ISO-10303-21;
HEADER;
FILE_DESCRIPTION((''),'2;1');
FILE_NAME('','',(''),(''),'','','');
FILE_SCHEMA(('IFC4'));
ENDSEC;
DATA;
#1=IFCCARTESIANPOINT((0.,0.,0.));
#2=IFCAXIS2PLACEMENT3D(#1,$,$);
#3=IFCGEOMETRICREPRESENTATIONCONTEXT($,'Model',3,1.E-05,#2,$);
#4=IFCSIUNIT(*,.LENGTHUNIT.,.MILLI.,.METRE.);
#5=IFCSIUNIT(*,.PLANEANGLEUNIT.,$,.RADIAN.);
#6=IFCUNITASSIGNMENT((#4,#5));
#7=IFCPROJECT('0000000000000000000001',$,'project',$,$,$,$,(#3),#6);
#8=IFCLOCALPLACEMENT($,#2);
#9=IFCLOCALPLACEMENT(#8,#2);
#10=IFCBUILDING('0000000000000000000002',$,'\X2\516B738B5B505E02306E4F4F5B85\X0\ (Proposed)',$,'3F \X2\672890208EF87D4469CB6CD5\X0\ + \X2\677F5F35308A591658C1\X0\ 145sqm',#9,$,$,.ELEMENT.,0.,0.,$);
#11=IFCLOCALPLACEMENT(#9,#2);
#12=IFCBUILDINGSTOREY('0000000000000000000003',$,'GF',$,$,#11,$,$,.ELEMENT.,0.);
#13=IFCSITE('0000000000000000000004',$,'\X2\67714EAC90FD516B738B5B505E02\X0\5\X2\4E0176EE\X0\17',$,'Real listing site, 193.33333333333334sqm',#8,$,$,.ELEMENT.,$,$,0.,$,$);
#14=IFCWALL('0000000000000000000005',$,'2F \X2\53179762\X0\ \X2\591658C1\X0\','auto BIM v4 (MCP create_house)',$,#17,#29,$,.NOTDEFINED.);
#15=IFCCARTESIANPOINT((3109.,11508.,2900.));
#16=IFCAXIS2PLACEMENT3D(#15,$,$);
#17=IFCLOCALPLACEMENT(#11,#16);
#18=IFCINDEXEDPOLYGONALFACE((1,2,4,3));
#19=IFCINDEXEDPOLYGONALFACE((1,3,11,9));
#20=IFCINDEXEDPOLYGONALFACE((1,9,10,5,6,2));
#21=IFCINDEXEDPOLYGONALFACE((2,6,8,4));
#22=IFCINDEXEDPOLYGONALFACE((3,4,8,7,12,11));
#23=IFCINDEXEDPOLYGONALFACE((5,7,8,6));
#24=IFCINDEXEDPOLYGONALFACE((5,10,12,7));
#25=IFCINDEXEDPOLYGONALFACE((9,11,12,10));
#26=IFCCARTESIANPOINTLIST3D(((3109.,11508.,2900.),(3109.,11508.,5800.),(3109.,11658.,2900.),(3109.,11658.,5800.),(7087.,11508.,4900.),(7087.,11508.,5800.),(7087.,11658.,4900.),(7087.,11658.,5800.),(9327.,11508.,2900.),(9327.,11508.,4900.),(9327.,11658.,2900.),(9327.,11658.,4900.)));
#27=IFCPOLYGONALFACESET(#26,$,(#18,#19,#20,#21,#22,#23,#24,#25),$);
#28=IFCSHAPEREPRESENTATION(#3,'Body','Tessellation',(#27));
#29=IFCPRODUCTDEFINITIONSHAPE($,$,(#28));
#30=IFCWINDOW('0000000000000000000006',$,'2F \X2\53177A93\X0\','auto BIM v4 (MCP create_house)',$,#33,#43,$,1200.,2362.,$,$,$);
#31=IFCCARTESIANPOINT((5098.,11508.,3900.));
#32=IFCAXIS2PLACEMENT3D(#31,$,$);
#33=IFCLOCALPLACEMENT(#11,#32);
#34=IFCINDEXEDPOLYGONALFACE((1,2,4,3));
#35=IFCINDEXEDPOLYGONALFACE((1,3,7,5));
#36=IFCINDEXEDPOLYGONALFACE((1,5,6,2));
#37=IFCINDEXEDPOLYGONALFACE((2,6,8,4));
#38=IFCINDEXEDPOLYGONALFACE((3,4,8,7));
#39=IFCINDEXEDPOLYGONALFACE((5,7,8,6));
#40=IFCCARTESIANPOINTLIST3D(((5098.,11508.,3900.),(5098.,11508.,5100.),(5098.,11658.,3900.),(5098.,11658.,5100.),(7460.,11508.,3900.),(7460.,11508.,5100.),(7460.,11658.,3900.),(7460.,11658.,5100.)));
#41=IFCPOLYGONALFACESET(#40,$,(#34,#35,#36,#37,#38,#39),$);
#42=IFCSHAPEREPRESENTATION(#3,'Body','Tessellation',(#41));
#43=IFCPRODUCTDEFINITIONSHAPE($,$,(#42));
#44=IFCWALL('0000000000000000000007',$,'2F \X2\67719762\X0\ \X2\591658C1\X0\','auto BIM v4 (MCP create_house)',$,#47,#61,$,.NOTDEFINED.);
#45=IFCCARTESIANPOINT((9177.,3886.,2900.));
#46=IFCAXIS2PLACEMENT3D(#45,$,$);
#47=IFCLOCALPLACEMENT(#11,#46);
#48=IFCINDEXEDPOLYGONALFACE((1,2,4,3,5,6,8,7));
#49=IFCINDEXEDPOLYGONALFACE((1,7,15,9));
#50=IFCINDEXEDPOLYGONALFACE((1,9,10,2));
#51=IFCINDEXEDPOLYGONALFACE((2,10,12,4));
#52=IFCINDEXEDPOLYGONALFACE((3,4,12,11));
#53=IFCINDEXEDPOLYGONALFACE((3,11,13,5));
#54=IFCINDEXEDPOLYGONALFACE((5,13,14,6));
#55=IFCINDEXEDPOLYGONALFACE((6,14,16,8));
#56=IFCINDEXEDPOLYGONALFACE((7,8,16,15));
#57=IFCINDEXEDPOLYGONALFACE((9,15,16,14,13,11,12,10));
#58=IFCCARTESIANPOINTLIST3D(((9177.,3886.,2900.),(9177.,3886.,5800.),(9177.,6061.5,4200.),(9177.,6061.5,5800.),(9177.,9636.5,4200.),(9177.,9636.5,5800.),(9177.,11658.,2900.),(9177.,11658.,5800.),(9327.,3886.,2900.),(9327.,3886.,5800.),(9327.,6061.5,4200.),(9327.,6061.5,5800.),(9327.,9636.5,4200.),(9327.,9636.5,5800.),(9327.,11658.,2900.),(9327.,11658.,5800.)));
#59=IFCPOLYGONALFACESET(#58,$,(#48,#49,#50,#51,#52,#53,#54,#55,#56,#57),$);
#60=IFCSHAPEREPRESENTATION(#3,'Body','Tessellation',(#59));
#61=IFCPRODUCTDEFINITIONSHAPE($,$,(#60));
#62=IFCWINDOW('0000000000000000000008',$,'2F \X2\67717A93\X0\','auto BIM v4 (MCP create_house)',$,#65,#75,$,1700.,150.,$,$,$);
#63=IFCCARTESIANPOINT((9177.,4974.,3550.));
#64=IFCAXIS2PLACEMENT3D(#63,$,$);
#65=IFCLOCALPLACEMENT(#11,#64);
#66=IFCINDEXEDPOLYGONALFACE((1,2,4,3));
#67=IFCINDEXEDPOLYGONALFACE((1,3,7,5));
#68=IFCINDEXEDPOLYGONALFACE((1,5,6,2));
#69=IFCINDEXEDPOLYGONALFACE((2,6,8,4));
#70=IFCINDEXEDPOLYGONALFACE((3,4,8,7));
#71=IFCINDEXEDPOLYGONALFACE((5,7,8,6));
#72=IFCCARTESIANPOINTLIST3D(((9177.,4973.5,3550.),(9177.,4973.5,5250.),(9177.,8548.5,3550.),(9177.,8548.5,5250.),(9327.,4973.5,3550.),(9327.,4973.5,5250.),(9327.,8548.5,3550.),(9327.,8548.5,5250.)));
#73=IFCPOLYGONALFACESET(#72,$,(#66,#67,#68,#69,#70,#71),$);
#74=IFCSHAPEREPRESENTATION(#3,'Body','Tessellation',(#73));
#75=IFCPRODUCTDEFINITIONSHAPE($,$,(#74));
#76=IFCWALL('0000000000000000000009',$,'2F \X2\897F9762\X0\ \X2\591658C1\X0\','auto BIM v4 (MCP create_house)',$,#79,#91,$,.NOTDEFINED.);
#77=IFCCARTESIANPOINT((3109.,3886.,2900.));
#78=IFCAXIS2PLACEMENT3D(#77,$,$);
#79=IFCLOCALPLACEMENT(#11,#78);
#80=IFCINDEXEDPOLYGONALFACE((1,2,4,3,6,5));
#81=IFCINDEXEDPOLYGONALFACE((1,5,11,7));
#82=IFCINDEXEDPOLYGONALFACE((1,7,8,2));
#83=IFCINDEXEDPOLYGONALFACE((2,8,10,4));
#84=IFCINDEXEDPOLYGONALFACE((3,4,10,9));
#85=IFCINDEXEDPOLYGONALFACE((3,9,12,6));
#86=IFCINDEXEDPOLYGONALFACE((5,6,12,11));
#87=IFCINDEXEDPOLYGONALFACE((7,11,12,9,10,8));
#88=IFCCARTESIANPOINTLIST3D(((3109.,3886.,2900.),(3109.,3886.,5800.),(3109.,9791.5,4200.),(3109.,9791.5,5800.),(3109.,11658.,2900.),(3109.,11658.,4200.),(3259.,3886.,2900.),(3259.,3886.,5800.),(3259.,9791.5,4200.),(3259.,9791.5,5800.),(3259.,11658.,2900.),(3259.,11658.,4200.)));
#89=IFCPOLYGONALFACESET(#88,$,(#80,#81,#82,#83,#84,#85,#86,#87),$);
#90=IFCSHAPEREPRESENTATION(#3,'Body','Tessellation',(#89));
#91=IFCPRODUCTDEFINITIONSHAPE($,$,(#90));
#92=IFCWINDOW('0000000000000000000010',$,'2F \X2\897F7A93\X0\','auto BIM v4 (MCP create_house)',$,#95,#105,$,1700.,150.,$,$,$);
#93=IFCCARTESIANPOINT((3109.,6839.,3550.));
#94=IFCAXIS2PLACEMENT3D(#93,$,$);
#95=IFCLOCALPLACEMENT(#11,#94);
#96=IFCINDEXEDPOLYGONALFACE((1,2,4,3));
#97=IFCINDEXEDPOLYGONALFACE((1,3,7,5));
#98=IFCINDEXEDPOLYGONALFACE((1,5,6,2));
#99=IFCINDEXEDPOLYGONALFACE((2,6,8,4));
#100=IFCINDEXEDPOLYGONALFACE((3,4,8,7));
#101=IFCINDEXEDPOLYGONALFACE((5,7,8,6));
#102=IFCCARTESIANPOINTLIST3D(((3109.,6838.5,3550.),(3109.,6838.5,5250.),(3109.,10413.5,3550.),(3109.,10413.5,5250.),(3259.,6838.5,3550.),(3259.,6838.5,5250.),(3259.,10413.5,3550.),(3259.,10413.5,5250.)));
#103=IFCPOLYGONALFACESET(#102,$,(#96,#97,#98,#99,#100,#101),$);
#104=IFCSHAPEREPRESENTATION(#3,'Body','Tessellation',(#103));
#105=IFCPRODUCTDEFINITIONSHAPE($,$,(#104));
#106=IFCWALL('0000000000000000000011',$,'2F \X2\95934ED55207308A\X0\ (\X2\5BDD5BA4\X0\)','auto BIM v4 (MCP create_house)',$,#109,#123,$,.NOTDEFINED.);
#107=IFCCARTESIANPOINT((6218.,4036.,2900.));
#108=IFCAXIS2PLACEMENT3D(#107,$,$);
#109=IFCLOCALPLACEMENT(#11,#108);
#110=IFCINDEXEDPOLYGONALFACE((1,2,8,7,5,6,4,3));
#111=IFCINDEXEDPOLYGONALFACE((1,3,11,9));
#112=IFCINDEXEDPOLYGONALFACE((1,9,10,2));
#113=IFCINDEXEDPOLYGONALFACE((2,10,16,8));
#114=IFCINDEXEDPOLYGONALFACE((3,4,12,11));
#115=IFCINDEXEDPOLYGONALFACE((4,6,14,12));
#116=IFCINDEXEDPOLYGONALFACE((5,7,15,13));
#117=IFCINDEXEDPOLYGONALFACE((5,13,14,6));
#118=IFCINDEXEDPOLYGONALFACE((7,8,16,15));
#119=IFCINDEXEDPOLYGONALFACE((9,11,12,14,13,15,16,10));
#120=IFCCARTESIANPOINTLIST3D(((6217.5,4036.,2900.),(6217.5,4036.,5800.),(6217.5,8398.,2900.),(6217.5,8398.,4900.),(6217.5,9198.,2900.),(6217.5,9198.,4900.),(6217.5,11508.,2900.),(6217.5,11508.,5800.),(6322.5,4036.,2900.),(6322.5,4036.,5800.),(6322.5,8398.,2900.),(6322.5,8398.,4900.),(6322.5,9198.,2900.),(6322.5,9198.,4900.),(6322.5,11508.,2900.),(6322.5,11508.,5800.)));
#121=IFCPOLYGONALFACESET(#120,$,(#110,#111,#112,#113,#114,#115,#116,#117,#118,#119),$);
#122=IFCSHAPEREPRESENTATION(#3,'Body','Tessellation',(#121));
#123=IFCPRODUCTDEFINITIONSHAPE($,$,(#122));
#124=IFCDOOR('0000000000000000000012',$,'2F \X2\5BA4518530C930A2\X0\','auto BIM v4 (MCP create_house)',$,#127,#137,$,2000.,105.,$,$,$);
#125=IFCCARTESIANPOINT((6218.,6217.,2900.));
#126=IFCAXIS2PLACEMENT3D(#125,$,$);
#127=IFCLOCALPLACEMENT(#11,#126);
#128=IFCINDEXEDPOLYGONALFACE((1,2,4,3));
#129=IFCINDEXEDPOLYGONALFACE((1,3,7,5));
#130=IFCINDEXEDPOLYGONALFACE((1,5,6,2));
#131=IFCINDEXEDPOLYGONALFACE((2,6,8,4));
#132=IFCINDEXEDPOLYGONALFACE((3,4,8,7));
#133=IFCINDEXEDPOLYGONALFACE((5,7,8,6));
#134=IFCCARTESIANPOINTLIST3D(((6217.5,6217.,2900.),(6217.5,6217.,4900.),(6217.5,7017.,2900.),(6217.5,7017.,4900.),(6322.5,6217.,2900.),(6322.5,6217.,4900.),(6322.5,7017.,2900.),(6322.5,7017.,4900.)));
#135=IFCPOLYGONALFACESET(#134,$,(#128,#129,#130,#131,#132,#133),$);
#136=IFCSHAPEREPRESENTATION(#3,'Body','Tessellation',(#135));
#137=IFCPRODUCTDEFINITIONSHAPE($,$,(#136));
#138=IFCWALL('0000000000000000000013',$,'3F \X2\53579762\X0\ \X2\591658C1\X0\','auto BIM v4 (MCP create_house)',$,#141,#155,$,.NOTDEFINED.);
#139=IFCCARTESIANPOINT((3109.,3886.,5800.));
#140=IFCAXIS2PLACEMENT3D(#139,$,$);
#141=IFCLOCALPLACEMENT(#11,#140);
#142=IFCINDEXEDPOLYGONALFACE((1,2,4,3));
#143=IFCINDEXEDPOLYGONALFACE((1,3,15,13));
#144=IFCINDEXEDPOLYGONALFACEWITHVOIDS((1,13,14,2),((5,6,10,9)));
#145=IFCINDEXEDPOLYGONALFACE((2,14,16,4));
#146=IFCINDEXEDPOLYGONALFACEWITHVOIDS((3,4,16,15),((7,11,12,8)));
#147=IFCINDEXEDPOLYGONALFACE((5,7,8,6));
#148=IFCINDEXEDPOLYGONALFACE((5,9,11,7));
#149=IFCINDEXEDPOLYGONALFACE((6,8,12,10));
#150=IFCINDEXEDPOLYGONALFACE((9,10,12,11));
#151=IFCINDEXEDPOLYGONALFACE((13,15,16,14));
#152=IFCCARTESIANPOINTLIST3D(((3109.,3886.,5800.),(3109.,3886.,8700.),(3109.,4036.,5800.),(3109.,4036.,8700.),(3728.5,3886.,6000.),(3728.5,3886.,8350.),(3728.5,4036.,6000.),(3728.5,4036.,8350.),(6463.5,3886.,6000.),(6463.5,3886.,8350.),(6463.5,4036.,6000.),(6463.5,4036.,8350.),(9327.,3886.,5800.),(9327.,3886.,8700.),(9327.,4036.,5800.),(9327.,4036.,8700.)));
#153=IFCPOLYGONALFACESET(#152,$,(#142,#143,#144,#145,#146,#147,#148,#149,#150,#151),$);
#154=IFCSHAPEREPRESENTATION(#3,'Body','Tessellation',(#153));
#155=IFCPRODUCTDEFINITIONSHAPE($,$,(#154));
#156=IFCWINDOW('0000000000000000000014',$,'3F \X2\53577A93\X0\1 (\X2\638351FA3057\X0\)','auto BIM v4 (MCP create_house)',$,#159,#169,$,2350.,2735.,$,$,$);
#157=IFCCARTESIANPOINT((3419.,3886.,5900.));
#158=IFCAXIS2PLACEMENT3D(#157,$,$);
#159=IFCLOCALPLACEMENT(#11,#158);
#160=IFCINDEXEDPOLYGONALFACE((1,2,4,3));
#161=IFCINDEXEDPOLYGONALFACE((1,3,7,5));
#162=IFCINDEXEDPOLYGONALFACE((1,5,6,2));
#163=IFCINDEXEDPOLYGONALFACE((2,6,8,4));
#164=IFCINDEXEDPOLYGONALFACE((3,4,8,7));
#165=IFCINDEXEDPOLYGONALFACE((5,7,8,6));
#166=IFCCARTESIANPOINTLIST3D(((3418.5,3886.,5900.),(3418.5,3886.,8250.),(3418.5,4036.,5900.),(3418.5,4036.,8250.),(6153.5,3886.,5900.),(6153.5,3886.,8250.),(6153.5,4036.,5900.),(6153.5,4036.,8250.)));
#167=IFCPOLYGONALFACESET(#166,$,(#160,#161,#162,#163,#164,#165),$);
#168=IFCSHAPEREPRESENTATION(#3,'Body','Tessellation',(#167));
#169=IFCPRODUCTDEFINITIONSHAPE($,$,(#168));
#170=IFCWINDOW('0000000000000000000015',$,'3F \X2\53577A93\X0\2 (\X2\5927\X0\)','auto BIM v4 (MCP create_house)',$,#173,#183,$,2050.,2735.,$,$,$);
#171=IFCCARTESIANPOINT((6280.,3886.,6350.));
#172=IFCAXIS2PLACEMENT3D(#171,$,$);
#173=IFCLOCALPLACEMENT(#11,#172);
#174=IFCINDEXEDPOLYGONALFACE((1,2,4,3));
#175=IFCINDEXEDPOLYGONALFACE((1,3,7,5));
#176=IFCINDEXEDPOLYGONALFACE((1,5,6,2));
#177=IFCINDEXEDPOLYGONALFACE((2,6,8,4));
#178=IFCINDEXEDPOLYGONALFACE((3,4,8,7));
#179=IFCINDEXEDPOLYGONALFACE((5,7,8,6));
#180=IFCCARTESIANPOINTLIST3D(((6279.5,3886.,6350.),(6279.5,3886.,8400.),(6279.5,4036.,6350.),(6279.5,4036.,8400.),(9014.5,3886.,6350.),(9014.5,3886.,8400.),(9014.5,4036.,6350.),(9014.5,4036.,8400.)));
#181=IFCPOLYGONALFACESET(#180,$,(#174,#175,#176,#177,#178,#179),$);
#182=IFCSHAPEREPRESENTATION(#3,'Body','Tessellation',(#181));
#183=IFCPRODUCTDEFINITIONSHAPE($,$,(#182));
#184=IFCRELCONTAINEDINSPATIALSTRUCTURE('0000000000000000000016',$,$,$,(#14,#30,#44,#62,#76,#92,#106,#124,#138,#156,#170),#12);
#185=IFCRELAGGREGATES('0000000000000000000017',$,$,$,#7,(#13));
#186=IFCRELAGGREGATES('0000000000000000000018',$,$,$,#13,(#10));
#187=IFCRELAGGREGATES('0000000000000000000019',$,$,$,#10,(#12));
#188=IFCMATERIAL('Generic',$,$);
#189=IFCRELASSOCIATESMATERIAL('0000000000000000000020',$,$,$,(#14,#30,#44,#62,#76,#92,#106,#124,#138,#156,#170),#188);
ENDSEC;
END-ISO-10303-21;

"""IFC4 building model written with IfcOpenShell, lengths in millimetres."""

from ifc_helpers import new_model, si_unit, frame, frame_2d, origin, place, context, project, spatial, rectangle, extrude, material, element, fill, save


model = new_model("IFC4")

# Units and contexts
model_context = context("Model", 3, precision=1e-05, world=origin())
ifc_project = project(units=[si_unit("LENGTHUNIT", "METRE", prefix="MILLI"), si_unit("PLANEANGLEUNIT", "RADIAN")], contexts=[model_context])

# Site, building, storey
site_placement = place(None, origin())
site = spatial("IfcSite", under=ifc_project, at=site_placement, Name="東京都八王子市5丁目17", ObjectType="Real listing site, 193.33333333333334sqm", CompositionType="ELEMENT", RefElevation=0.0)
building_placement = place(site_placement, origin())
building = spatial("IfcBuilding", under=site, at=building_placement, Name="八王子市の住宅 (Proposed)", ObjectType="3F 木造軸組構法 + 板張り外壁 145sqm", CompositionType="ELEMENT", ElevationOfRefHeight=0.0, ElevationOfTerrain=0.0)
storey_placement = place(building_placement, origin())
storey = spatial("IfcBuildingStorey", under=building, at=storey_placement, Name="GF", CompositionType="ELEMENT", Elevation=0.0)

# Shared definitions
ifc_material = material(Name="Generic")

# Walls, openings, windows
wall_1_placement = place(storey_placement, frame((3109.0, 11508.0, 2900.0)))
wall_1 = element("IfcWall", 1, at=wall_1_placement, inside=storey, material=ifc_material, Name="2F 北面 外壁", Description="auto BIM v4 (MCP create_house)", PredefinedType="NOTDEFINED", context=model_context, shape_type="SweptSolid", body=[
    extrude(rectangle(XDim=6218.0, YDim=150.0, at=frame_2d((3109.0, 75.0))), frame((3109.0, 11508.0, 2900.0)), (0.0, 0.0, 1.0), 2900.0),
])
opening_1_placement = place(storey_placement, frame((5098.0, 11508.0, 3900.0)))
opening_1 = element("IfcOpeningElement", 2, at=opening_1_placement, cuts=wall_1, PredefinedType="NOTDEFINED", context=model_context, shape_type="SweptSolid", body=[
    extrude(rectangle(XDim=2362.0, YDim=150.0, at=frame_2d((1181.0, 75.0))), frame((5098.0, 11508.0, 3900.0)), (0.0, 0.0, 1.0), 1200.0),
])
window_1_placement = place(storey_placement, frame((5098.0, 11508.0, 3900.0)))
window_1 = element("IfcWindow", 3, at=window_1_placement, inside=storey, material=ifc_material, Name="2F 北窓", Description="auto BIM v4 (MCP create_house)", OverallHeight=1200.0, OverallWidth=2362.0, context=model_context, shape_type="SweptSolid", body=[
    extrude(rectangle(XDim=2362.0, YDim=150.0, at=frame_2d((1181.0, 75.0))), frame((5098.0, 11508.0, 3900.0)), (0.0, 0.0, 1.0), 1200.0),
])
fill(opening_1, window_1)
wall_2_placement = place(storey_placement, frame((9177.0, 3886.0, 2900.0)))
wall_2 = element("IfcWall", 4, at=wall_2_placement, inside=storey, material=ifc_material, Name="2F 東面 外壁", Description="auto BIM v4 (MCP create_house)", PredefinedType="NOTDEFINED", context=model_context, shape_type="SweptSolid", body=[
    extrude(rectangle(XDim=150.0, YDim=7772.0, at=frame_2d((75.0, 3886.0))), frame((9177.0, 3886.0, 2900.0)), (0.0, 0.0, 1.0), 2900.0),
])
opening_2_placement = place(storey_placement, frame((9177.0, 4974.0, 3550.0)))
opening_2 = element("IfcOpeningElement", 5, at=opening_2_placement, cuts=wall_2, PredefinedType="NOTDEFINED", context=model_context, shape_type="SweptSolid", body=[
    extrude(rectangle(XDim=150.0, YDim=3575.0, at=frame_2d((75.0, 1787.0))), frame((9177.0, 4974.0, 3550.0)), (0.0, 0.0, 1.0), 1700.0),
])
window_2_placement = place(storey_placement, frame((9177.0, 4974.0, 3550.0)))
window_2 = element("IfcWindow", 6, at=window_2_placement, inside=storey, material=ifc_material, Name="2F 東窓", Description="auto BIM v4 (MCP create_house)", OverallHeight=1700.0, OverallWidth=150.0, context=model_context, shape_type="SweptSolid", body=[
    extrude(rectangle(XDim=150.0, YDim=3575.0, at=frame_2d((75.0, 1787.0))), frame((9177.0, 4974.0, 3550.0)), (0.0, 0.0, 1.0), 1700.0),
])
fill(opening_2, window_2)
wall_3_placement = place(storey_placement, frame((3109.0, 3886.0, 2900.0)))
wall_3 = element("IfcWall", 7, at=wall_3_placement, inside=storey, material=ifc_material, Name="2F 西面 外壁", Description="auto BIM v4 (MCP create_house)", PredefinedType="NOTDEFINED", context=model_context, shape_type="SweptSolid", body=[
    extrude(rectangle(XDim=150.0, YDim=7772.0, at=frame_2d((75.0, 3886.0))), frame((3109.0, 3886.0, 2900.0)), (0.0, 0.0, 1.0), 2900.0),
])
opening_3_placement = place(storey_placement, frame((3109.0, 6839.0, 3550.0)))
opening_3 = element("IfcOpeningElement", 8, at=opening_3_placement, cuts=wall_3, PredefinedType="NOTDEFINED", context=model_context, shape_type="SweptSolid", body=[
    extrude(rectangle(XDim=150.0, YDim=3575.0, at=frame_2d((75.0, 1787.0))), frame((3109.0, 6839.0, 3550.0)), (0.0, 0.0, 1.0), 1700.0),
])
window_3_placement = place(storey_placement, frame((3109.0, 6839.0, 3550.0)))
window_3 = element("IfcWindow", 9, at=window_3_placement, inside=storey, material=ifc_material, Name="2F 西窓", Description="auto BIM v4 (MCP create_house)", OverallHeight=1700.0, OverallWidth=150.0, context=model_context, shape_type="SweptSolid", body=[
    extrude(rectangle(XDim=150.0, YDim=3575.0, at=frame_2d((75.0, 1787.0))), frame((3109.0, 6839.0, 3550.0)), (0.0, 0.0, 1.0), 1700.0),
])
fill(opening_3, window_3)

# Wall, opening, door
wall_4_placement = place(storey_placement, frame((6218.0, 4036.0, 2900.0)))
wall_4 = element("IfcWall", 10, at=wall_4_placement, inside=storey, material=ifc_material, Name="2F 間仕切り (寝室)", Description="auto BIM v4 (MCP create_house)", PredefinedType="NOTDEFINED", context=model_context, shape_type="SweptSolid", body=[
    extrude(rectangle(XDim=105.0, YDim=7472.0, at=frame_2d((52.0, 3736.0))), frame((6218.0, 4036.0, 2900.0)), (0.0, 0.0, 1.0), 2900.0),
])
opening_4_placement = place(storey_placement, frame((6218.0, 6217.0, 2900.0)))
opening_4 = element("IfcOpeningElement", 11, at=opening_4_placement, cuts=wall_4, PredefinedType="NOTDEFINED", context=model_context, shape_type="SweptSolid", body=[
    extrude(rectangle(XDim=105.0, YDim=800.0, at=frame_2d((52.0, 400.0))), frame((6218.0, 6217.0, 2900.0)), (0.0, 0.0, 1.0), 2000.0),
])
door_1_placement = place(storey_placement, frame((6218.0, 6217.0, 2900.0)))
door_1 = element("IfcDoor", 12, at=door_1_placement, inside=storey, material=ifc_material, Name="2F 室内ドア", Description="auto BIM v4 (MCP create_house)", OverallHeight=2000.0, OverallWidth=105.0, context=model_context, shape_type="SweptSolid", body=[
    extrude(rectangle(XDim=105.0, YDim=800.0, at=frame_2d((52.0, 400.0))), frame((6218.0, 6217.0, 2900.0)), (0.0, 0.0, 1.0), 2000.0),
])
fill(opening_4, door_1)

# Wall, openings, windows
wall_5_placement = place(storey_placement, frame((3109.0, 3886.0, 5800.0)))
wall_5 = element("IfcWall", 13, at=wall_5_placement, inside=storey, material=ifc_material, Name="3F 南面 外壁", Description="auto BIM v4 (MCP create_house)", PredefinedType="NOTDEFINED", context=model_context, shape_type="SweptSolid", body=[
    extrude(rectangle(XDim=6218.0, YDim=150.0, at=frame_2d((3109.0, 75.0))), frame((3109.0, 3886.0, 5800.0)), (0.0, 0.0, 1.0), 2900.0),
])
opening_5_placement = place(storey_placement, frame((3419.0, 3886.0, 5900.0)))
opening_5 = element("IfcOpeningElement", 14, at=opening_5_placement, cuts=wall_5, PredefinedType="NOTDEFINED", context=model_context, shape_type="SweptSolid", body=[
    extrude(rectangle(XDim=2735.0, YDim=150.0, at=frame_2d((1367.0, 75.0))), frame((3419.0, 3886.0, 5900.0)), (0.0, 0.0, 1.0), 2350.0),
])
opening_6_placement = place(storey_placement, frame((6280.0, 3886.0, 6350.0)))
opening_6 = element("IfcOpeningElement", 15, at=opening_6_placement, cuts=wall_5, PredefinedType="NOTDEFINED", context=model_context, shape_type="SweptSolid", body=[
    extrude(rectangle(XDim=2735.0, YDim=150.0, at=frame_2d((1367.0, 75.0))), frame((6280.0, 3886.0, 6350.0)), (0.0, 0.0, 1.0), 2050.0),
])
window_4_placement = place(storey_placement, frame((3419.0, 3886.0, 5900.0)))
window_4 = element("IfcWindow", 16, at=window_4_placement, inside=storey, material=ifc_material, Name="3F 南窓1 (掃出し)", Description="auto BIM v4 (MCP create_house)", OverallHeight=2350.0, OverallWidth=2735.0, context=model_context, shape_type="SweptSolid", body=[
    extrude(rectangle(XDim=2735.0, YDim=150.0, at=frame_2d((1367.0, 75.0))), frame((3419.0, 3886.0, 5900.0)), (0.0, 0.0, 1.0), 2350.0),
])
fill(opening_5, window_4)
window_5_placement = place(storey_placement, frame((6280.0, 3886.0, 6350.0)))
window_5 = element("IfcWindow", 17, at=window_5_placement, inside=storey, material=ifc_material, Name="3F 南窓2 (大)", Description="auto BIM v4 (MCP create_house)", OverallHeight=2050.0, OverallWidth=2735.0, context=model_context, shape_type="SweptSolid", body=[
    extrude(rectangle(XDim=2735.0, YDim=150.0, at=frame_2d((1367.0, 75.0))), frame((6280.0, 3886.0, 6350.0)), (0.0, 0.0, 1.0), 2050.0),
])
fill(opening_6, window_5)

save(model, "model.ifc")
